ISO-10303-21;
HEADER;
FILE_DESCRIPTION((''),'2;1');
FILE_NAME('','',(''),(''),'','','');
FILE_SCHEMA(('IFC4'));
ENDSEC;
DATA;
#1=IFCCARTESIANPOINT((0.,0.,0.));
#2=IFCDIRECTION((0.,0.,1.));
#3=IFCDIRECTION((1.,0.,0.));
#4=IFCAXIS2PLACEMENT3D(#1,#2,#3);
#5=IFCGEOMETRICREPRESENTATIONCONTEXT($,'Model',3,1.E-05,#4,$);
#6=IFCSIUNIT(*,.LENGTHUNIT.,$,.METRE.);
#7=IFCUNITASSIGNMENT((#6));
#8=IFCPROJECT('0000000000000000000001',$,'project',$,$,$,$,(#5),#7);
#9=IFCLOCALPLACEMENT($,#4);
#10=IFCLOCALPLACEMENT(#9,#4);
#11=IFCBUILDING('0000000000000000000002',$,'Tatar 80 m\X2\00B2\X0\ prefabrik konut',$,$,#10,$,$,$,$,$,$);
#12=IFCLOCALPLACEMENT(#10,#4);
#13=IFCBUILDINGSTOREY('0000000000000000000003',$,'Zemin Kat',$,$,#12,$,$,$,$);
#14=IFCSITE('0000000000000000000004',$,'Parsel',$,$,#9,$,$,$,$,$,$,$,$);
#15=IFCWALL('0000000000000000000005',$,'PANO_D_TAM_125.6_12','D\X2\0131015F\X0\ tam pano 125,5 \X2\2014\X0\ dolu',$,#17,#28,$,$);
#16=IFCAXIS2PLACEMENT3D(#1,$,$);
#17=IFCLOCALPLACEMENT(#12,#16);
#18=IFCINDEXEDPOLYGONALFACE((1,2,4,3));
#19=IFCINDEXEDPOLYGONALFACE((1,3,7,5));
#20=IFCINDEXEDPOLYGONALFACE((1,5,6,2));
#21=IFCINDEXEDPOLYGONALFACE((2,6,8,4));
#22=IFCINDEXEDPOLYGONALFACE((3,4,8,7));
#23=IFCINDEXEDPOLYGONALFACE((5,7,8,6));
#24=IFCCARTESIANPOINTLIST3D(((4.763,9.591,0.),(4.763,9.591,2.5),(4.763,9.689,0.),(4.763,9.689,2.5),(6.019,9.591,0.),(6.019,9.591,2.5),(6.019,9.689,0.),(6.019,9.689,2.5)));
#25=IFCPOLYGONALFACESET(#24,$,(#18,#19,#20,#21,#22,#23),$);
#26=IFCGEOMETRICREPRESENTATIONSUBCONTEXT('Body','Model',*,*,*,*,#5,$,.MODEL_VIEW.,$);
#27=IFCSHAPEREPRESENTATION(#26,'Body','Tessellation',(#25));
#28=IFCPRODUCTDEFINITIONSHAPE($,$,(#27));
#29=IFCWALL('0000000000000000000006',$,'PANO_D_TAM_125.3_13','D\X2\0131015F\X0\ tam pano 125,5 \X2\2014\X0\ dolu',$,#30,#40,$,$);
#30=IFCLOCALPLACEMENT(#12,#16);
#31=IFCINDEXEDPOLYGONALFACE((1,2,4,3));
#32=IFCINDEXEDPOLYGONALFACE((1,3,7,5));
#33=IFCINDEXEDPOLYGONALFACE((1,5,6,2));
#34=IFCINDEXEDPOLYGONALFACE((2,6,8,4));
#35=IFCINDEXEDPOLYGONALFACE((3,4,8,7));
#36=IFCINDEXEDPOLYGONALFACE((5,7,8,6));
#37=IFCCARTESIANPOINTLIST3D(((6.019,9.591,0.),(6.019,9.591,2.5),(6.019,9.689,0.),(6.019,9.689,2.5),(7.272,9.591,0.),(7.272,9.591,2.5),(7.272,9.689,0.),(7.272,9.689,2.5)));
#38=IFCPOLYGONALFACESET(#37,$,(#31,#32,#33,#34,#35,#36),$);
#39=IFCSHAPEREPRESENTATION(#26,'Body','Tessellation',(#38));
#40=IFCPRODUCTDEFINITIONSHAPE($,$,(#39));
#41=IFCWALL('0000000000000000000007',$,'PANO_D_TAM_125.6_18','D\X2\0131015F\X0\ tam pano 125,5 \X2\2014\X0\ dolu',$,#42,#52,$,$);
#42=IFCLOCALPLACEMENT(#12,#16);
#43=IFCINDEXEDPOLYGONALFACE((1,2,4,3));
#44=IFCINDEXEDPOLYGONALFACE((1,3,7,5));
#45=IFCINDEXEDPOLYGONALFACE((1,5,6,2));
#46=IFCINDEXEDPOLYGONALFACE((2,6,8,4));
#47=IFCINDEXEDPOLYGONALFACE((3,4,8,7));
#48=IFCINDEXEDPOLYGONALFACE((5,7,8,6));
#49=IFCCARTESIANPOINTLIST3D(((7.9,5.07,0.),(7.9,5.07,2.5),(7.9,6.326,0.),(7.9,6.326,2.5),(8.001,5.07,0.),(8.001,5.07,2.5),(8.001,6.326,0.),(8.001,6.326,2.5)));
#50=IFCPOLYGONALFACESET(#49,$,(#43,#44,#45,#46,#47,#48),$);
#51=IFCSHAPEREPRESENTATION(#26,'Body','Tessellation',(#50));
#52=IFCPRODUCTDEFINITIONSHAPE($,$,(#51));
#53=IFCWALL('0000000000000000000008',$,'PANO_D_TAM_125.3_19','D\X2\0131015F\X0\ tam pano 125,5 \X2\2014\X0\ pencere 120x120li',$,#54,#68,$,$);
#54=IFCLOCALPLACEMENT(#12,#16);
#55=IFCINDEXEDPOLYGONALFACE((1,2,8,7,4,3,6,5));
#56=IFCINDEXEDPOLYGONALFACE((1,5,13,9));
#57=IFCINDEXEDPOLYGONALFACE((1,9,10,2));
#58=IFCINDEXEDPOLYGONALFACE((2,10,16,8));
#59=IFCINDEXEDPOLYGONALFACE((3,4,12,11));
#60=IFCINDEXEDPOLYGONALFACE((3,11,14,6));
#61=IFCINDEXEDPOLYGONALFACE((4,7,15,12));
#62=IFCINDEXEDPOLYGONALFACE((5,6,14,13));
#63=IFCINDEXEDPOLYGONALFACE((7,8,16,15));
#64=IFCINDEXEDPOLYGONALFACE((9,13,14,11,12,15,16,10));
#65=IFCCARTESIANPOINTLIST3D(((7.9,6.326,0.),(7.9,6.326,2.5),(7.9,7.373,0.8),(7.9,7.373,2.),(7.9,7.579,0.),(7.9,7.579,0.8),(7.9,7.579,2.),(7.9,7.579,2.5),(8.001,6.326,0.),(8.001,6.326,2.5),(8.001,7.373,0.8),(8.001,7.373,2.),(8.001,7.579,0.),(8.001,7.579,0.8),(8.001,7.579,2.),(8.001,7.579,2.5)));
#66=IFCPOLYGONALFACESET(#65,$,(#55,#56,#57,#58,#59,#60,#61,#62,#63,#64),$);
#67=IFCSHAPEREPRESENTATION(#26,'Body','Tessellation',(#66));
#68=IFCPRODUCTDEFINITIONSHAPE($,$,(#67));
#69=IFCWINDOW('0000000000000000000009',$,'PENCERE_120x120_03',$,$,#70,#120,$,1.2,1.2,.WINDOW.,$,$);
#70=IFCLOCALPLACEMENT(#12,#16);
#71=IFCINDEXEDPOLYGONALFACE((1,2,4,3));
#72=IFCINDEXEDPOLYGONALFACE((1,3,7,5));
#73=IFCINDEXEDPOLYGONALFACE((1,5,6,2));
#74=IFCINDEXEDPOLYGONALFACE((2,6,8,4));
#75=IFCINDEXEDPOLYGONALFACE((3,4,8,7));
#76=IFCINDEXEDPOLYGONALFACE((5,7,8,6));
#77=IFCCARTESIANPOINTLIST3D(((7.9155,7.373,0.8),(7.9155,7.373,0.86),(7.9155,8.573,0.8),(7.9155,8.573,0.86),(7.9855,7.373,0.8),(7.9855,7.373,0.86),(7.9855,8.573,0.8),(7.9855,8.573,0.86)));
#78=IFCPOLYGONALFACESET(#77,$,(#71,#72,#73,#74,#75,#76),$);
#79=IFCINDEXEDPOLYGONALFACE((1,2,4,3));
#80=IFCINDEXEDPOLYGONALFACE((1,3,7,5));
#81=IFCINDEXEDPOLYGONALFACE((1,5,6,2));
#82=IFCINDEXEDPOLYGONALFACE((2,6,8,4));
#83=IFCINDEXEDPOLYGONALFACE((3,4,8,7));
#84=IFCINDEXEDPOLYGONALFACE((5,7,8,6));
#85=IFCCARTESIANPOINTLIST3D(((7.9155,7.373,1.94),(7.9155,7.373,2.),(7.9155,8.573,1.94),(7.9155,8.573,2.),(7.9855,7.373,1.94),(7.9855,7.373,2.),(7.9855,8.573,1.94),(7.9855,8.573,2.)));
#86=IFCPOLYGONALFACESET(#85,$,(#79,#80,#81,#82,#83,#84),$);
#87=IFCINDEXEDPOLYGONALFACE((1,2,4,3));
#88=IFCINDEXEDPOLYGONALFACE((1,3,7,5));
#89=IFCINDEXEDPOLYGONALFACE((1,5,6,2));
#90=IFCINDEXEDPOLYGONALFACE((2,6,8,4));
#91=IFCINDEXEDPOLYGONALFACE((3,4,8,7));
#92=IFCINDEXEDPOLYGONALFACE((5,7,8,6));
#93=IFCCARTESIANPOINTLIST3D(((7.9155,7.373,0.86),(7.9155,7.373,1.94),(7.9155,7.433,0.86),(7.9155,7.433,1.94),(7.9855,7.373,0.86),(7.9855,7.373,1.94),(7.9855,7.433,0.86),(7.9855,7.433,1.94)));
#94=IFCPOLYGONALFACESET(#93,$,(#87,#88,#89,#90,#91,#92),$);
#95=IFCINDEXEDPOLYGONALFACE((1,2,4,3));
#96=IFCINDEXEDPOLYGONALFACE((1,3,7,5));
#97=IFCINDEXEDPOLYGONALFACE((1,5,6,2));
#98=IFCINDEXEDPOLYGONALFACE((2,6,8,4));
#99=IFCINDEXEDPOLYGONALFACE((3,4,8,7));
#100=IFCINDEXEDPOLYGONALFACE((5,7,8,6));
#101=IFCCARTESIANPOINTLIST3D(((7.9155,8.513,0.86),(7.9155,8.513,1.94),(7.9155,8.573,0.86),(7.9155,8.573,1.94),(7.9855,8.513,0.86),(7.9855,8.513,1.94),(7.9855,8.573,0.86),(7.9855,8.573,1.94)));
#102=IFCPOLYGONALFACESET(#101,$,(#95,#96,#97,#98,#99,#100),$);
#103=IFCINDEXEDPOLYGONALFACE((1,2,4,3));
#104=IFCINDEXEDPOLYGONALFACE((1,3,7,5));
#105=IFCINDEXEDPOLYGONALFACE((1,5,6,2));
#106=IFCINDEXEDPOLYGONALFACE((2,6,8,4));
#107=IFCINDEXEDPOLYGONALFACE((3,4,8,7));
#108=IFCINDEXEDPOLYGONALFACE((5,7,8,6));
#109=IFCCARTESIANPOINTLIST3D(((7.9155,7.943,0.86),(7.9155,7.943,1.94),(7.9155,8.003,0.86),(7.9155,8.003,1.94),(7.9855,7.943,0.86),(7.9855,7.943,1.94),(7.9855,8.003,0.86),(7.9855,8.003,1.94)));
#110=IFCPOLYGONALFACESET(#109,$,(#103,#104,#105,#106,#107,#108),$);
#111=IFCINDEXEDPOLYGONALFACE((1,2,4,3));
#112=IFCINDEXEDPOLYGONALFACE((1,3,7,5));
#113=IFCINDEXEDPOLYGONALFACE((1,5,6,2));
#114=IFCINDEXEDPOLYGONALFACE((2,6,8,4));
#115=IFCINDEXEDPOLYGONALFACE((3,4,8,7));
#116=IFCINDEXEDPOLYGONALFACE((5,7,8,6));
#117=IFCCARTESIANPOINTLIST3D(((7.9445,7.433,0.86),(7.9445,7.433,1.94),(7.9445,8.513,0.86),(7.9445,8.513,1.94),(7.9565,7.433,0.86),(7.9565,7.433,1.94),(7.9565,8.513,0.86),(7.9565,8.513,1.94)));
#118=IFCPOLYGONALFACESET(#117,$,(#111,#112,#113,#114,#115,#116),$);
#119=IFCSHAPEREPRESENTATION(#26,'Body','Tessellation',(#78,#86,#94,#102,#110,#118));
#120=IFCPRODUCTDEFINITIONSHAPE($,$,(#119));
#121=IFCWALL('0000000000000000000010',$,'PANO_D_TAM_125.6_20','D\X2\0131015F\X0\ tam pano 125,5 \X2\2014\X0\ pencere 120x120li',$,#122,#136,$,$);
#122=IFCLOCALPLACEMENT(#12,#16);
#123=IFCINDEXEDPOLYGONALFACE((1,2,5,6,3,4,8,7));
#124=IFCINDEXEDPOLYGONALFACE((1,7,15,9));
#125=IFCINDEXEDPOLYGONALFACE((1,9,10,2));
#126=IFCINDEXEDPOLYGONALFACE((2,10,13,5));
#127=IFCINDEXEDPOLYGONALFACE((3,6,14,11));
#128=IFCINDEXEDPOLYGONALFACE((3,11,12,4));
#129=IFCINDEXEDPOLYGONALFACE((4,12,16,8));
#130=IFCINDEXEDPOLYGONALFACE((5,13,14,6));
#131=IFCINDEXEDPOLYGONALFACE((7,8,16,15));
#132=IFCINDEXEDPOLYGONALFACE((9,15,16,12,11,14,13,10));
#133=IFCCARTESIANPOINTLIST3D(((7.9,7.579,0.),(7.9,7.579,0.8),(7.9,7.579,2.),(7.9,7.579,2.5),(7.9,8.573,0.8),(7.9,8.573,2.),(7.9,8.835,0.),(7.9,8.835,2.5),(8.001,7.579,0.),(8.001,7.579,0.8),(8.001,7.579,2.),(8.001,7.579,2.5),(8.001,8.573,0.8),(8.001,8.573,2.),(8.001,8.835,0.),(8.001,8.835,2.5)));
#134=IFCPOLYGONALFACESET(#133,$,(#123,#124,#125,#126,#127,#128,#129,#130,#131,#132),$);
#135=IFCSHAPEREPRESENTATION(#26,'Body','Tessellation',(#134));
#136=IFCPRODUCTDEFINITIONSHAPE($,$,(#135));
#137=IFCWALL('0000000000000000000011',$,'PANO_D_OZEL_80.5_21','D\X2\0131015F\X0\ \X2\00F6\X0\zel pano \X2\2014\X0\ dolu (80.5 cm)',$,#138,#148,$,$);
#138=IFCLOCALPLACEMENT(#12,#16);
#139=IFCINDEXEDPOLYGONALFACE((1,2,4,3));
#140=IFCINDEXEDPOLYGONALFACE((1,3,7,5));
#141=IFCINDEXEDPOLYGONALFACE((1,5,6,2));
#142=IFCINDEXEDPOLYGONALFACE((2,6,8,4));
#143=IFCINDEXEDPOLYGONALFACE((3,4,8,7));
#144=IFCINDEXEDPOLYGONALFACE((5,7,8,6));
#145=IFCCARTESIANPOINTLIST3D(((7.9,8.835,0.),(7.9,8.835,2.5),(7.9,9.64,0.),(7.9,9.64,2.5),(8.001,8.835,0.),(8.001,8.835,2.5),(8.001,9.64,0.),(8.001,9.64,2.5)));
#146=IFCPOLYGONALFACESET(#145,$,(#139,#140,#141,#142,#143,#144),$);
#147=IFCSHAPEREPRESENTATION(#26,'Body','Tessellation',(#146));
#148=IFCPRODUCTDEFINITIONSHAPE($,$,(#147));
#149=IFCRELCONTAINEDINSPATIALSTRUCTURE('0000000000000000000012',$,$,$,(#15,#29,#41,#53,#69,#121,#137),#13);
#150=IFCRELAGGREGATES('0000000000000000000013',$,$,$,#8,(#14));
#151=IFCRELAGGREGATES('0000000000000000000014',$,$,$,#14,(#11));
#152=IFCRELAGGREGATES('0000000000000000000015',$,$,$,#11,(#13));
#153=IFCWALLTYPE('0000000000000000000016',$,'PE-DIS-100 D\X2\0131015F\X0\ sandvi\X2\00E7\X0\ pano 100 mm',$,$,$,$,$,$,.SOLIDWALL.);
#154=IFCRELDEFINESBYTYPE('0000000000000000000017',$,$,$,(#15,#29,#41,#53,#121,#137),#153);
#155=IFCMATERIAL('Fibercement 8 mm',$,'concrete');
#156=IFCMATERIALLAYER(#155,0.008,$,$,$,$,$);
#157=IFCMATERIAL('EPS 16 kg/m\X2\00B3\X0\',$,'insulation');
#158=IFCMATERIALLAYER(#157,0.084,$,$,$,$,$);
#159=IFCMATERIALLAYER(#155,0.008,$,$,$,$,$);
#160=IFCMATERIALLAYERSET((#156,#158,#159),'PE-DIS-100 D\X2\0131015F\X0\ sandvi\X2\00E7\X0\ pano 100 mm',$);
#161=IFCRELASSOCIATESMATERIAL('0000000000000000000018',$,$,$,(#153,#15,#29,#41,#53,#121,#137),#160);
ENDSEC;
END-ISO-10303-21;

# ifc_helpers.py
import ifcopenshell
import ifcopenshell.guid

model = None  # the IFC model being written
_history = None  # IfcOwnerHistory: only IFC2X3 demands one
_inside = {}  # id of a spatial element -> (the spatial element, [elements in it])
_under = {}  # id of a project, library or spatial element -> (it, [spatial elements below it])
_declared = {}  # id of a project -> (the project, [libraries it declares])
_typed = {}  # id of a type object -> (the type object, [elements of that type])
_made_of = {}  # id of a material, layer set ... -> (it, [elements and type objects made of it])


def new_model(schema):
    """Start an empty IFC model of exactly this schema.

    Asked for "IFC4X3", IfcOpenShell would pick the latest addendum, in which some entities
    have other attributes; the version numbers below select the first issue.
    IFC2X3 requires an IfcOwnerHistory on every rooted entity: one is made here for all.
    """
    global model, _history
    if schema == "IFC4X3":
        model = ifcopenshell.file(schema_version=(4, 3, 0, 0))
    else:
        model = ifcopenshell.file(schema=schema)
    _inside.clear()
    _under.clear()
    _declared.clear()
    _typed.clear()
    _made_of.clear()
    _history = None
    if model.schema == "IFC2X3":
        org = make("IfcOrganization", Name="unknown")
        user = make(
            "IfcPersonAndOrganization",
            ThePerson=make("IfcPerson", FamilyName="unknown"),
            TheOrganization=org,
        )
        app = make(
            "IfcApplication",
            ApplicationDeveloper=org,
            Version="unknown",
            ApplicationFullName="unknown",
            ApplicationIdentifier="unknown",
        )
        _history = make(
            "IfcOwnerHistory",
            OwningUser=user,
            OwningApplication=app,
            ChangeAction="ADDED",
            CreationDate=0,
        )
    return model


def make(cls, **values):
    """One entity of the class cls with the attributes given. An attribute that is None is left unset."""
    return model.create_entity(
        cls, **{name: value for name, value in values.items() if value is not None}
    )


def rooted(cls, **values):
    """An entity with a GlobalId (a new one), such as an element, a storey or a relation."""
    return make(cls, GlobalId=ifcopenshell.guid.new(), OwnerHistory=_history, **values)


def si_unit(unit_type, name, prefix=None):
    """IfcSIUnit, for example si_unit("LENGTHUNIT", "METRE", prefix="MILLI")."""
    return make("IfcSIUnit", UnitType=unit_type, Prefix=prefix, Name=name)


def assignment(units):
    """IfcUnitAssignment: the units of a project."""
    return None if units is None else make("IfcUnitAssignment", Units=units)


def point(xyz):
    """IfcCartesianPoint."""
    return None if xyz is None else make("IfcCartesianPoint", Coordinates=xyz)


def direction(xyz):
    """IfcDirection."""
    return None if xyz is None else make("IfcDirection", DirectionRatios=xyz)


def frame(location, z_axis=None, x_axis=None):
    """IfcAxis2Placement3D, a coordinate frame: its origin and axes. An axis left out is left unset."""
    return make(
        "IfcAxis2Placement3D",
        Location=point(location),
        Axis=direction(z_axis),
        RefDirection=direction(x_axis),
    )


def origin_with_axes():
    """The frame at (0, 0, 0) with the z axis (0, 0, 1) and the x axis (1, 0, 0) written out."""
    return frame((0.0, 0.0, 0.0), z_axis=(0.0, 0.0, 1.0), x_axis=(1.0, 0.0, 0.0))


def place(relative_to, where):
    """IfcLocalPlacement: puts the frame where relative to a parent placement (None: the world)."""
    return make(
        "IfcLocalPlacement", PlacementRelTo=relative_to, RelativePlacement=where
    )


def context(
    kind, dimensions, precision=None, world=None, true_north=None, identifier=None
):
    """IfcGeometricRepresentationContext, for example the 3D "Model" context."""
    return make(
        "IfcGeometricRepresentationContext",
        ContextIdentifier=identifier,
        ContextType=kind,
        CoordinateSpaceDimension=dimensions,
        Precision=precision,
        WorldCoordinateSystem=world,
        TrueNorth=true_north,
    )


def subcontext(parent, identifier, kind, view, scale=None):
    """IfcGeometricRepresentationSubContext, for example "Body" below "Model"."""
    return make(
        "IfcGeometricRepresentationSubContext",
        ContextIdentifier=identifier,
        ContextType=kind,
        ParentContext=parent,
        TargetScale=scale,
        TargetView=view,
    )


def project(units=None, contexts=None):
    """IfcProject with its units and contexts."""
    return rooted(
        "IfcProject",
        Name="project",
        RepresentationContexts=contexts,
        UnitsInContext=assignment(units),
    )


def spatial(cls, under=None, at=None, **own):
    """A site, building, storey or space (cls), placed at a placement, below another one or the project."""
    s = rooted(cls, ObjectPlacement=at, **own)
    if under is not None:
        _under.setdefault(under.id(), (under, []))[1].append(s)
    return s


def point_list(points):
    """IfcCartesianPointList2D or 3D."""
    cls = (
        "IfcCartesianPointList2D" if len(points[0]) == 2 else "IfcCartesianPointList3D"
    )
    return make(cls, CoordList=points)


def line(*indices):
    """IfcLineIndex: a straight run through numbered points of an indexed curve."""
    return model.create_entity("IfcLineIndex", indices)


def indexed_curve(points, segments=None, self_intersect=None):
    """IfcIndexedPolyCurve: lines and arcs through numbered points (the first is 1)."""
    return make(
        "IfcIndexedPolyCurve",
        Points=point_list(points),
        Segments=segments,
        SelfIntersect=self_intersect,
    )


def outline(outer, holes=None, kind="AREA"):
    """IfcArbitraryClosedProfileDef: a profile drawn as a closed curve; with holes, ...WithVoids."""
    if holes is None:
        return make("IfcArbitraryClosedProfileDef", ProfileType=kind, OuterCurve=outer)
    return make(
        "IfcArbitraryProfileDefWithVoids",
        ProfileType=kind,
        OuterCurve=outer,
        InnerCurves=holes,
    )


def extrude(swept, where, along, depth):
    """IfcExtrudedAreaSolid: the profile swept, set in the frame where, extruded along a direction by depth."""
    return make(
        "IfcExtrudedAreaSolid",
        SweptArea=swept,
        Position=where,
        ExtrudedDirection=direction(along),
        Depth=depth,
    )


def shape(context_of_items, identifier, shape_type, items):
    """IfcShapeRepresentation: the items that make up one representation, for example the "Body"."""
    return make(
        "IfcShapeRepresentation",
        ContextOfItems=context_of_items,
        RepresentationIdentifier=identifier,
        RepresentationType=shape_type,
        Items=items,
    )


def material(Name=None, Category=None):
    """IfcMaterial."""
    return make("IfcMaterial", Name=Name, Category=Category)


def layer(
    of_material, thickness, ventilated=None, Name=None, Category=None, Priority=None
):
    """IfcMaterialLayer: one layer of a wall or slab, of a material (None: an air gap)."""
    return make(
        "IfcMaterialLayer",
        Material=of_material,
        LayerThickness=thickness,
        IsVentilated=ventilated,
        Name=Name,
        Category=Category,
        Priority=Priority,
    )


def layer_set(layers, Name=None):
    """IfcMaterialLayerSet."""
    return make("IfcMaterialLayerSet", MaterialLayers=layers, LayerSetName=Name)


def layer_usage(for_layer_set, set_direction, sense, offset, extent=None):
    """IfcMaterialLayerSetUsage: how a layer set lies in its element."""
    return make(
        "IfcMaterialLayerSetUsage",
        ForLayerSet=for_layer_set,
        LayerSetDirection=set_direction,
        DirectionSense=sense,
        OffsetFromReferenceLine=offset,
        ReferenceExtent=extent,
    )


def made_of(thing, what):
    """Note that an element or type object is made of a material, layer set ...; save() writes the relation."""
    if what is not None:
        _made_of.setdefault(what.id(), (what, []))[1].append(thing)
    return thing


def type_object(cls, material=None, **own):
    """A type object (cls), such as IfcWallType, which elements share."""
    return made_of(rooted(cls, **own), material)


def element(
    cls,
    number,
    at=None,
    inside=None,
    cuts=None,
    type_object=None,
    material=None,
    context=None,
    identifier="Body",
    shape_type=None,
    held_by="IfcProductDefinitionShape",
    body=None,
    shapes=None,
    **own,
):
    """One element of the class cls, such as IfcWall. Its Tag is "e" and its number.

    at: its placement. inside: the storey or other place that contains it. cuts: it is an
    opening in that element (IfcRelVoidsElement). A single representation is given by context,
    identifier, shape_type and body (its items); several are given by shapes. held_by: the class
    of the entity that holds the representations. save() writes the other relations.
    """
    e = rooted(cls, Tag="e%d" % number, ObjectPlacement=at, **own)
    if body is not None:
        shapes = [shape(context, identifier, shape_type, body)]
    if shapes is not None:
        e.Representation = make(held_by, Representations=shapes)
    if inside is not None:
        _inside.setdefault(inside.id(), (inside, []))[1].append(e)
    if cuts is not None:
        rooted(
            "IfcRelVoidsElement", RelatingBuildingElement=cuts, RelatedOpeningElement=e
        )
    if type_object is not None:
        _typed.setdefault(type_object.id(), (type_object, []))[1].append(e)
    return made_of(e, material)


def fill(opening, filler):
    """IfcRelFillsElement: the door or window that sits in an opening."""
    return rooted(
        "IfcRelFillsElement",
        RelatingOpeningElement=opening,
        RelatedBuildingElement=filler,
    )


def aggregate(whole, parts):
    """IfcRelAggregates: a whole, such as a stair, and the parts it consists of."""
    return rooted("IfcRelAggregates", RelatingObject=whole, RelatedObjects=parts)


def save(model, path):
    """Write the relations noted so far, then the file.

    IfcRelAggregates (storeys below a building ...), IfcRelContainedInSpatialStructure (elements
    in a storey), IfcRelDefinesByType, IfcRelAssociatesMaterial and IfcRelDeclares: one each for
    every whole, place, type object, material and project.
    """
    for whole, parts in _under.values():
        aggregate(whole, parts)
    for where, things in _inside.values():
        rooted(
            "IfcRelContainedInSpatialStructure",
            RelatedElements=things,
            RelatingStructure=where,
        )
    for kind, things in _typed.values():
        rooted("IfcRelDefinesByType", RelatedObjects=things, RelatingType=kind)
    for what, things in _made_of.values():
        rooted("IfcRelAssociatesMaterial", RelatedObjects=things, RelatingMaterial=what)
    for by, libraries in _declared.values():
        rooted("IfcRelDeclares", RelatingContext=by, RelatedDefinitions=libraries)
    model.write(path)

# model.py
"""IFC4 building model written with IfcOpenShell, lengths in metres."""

from ifc_helpers import new_model, si_unit, frame, origin_with_axes, place, context, subcontext, project, spatial, line, indexed_curve, outline, extrude, material, layer, layer_set, layer_usage, type_object, element, fill, save


model = new_model("IFC4")

# Units and contexts
model_context = context("Model", 3, precision=1e-05, world=origin_with_axes())
body_context = subcontext(model_context, "Body", "Model", "MODEL_VIEW")
ifc_project = project(units=[si_unit("LENGTHUNIT", "METRE")], contexts=[model_context])

# Site, building, storey
site_placement = place(None, origin_with_axes())
site = spatial("IfcSite", under=ifc_project, at=site_placement, Name="Parsel")
building_placement = place(site_placement, origin_with_axes())
building = spatial("IfcBuilding", under=site, at=building_placement, Name="Tatar 80 m² prefabrik konut")
storey_placement = place(building_placement, origin_with_axes())
storey = spatial("IfcBuildingStorey", under=building, at=storey_placement, Name="Zemin Kat")

# Walls
ifc_material_1 = material(Name="Fibercement 8 mm", Category="concrete")
ifc_layer_1 = layer(ifc_material_1, 0.008)
ifc_material_2 = material(Name="EPS 16 kg/m³", Category="insulation")
ifc_layer_2 = layer(ifc_material_2, 0.084)
ifc_layer_3 = layer(ifc_material_1, 0.008)
ifc_layer_set_1 = layer_set([ifc_layer_1, ifc_layer_2, ifc_layer_3], Name="PE-DIS-100 Dış sandviç pano 100 mm")
ifc_layer_usage_1 = layer_usage(ifc_layer_set_1, "AXIS2", "POSITIVE", 0.0)
wall_type_1 = type_object("IfcWallType", Name="PE-DIS-100 Dış sandviç pano 100 mm", PredefinedType="SOLIDWALL", material=ifc_layer_set_1)
wall_1_placement = place(storey_placement, frame((4.763, 9.591, 0.0), z_axis=(0.0, 0.0, 1.0), x_axis=(1.0, 0.0, 0.0)))
element("IfcWall", 1, at=wall_1_placement, inside=storey, type_object=wall_type_1, material=ifc_layer_usage_1, Name="PANO_D_TAM_125.6_12", Description="Dış tam pano 125,5 — dolu", context=body_context, shape_type="SweptSolid", body=[
    extrude(outline(indexed_curve([(0.0, 0.0), (1.256, 0.0), (1.256, 0.098), (0.0, 0.098)], segments=[line(1, 2, 3, 4, 1)])), origin_with_axes(), (0.0, 0.0, 1.0), 2.5),
])
ifc_layer_usage_2 = layer_usage(ifc_layer_set_1, "AXIS2", "POSITIVE", 0.0)
wall_2_placement = place(storey_placement, frame((6.019, 9.591, 0.0), z_axis=(0.0, 0.0, 1.0), x_axis=(1.0, 0.0, 0.0)))
element("IfcWall", 2, at=wall_2_placement, inside=storey, type_object=wall_type_1, material=ifc_layer_usage_2, Name="PANO_D_TAM_125.3_13", Description="Dış tam pano 125,5 — dolu", context=body_context, shape_type="SweptSolid", body=[
    extrude(outline(indexed_curve([(0.0, 0.0), (1.253, 0.0), (1.253, 0.098), (0.0, 0.098)], segments=[line(1, 2, 3, 4, 1)])), origin_with_axes(), (0.0, 0.0, 1.0), 2.5),
])
ifc_layer_usage_3 = layer_usage(ifc_layer_set_1, "AXIS2", "POSITIVE", 0.0)
wall_3_placement = place(storey_placement, frame((8.001, 5.07, 0.0), z_axis=(0.0, 0.0, 1.0), x_axis=(0.0, 1.0, 0.0)))
element("IfcWall", 3, at=wall_3_placement, inside=storey, type_object=wall_type_1, material=ifc_layer_usage_3, Name="PANO_D_TAM_125.6_18", Description="Dış tam pano 125,5 — dolu", context=body_context, shape_type="SweptSolid", body=[
    extrude(outline(indexed_curve([(0.0, 0.0), (1.256, 0.0), (1.256, 0.101), (0.0, 0.101)], segments=[line(1, 2, 3, 4, 1)])), origin_with_axes(), (0.0, 0.0, 1.0), 2.5),
])

# Wall, opening, window
ifc_layer_usage_4 = layer_usage(ifc_layer_set_1, "AXIS2", "POSITIVE", 0.0)
wall_4_placement = place(storey_placement, frame((8.001, 6.326, 0.0), z_axis=(0.0, 0.0, 1.0), x_axis=(0.0, 1.0, 0.0)))
wall_4 = element("IfcWall", 4, at=wall_4_placement, inside=storey, type_object=wall_type_1, material=ifc_layer_usage_4, Name="PANO_D_TAM_125.3_19", Description="Dış tam pano 125,5 — pencere 120x120li", context=body_context, shape_type="SweptSolid", body=[
    extrude(outline(indexed_curve([(0.0, 0.0), (1.253, 0.0), (1.253, 0.101), (0.0, 0.101)], segments=[line(1, 2, 3, 4, 1)])), origin_with_axes(), (0.0, 0.0, 1.0), 2.5),
])
opening_1_placement = place(wall_4_placement, origin_with_axes())
opening_1 = element("IfcOpeningElement", 5, at=opening_1_placement, cuts=wall_4, PredefinedType="OPENING", context=body_context, shape_type="SweptSolid", body=[
    extrude(outline(indexed_curve([(0.0, 0.0), (0.206, 0.0), (0.206, 0.141), (0.0, 0.141)], segments=[line(1, 2, 3, 4, 1)])), frame((1.047, -0.02, 0.8), z_axis=(0.0, 0.0, 1.0), x_axis=(1.0, 0.0, 0.0)), (0.0, 0.0, 1.0), 1.2),
])
window_1_placement = place(storey_placement, frame((8.001, 6.326, 0.0), z_axis=(0.0, 0.0, 1.0), x_axis=(0.0, 1.0, 0.0)))
window_1 = element("IfcWindow", 6, at=window_1_placement, inside=storey, Name="PENCERE_120x120_03", OverallHeight=1.2, OverallWidth=1.2, PredefinedType="WINDOW", context=body_context, shape_type="SweptSolid", body=[
    extrude(outline(indexed_curve([(0.0, 0.0), (1.2, 0.0), (1.2, 0.07), (0.0, 0.07)], segments=[line(1, 2, 3, 4, 1)])), frame((1.047, 0.0155, 0.8), z_axis=(0.0, 0.0, 1.0), x_axis=(1.0, 0.0, 0.0)), (0.0, 0.0, 1.0), 0.06),
    extrude(outline(indexed_curve([(0.0, 0.0), (1.2, 0.0), (1.2, 0.07), (0.0, 0.07)], segments=[line(1, 2, 3, 4, 1)])), frame((1.047, 0.0155, 1.94), z_axis=(0.0, 0.0, 1.0), x_axis=(1.0, 0.0, 0.0)), (0.0, 0.0, 1.0), 0.06),
    extrude(outline(indexed_curve([(0.0, 0.0), (0.06, 0.0), (0.06, 0.07), (0.0, 0.07)], segments=[line(1, 2, 3, 4, 1)])), frame((1.047, 0.0155, 0.86), z_axis=(0.0, 0.0, 1.0), x_axis=(1.0, 0.0, 0.0)), (0.0, 0.0, 1.0), 1.08),
    extrude(outline(indexed_curve([(0.0, 0.0), (0.06, 0.0), (0.06, 0.07), (0.0, 0.07)], segments=[line(1, 2, 3, 4, 1)])), frame((2.187, 0.0155, 0.86), z_axis=(0.0, 0.0, 1.0), x_axis=(1.0, 0.0, 0.0)), (0.0, 0.0, 1.0), 1.08),
    extrude(outline(indexed_curve([(0.0, 0.0), (0.06, 0.0), (0.06, 0.07), (0.0, 0.07)], segments=[line(1, 2, 3, 4, 1)])), frame((1.617, 0.0155, 0.86), z_axis=(0.0, 0.0, 1.0), x_axis=(1.0, 0.0, 0.0)), (0.0, 0.0, 1.0), 1.08),
    extrude(outline(indexed_curve([(0.0, 0.0), (1.08, 0.0), (1.08, 0.012), (0.0, 0.012)], segments=[line(1, 2, 3, 4, 1)])), frame((1.107, 0.0445, 0.86), z_axis=(0.0, 0.0, 1.0), x_axis=(1.0, 0.0, 0.0)), (0.0, 0.0, 1.0), 1.08),
])
fill(opening_1, window_1)

# Wall, opening
ifc_layer_usage_5 = layer_usage(ifc_layer_set_1, "AXIS2", "POSITIVE", 0.0)
wall_5_placement = place(storey_placement, frame((8.001, 7.579, 0.0), z_axis=(0.0, 0.0, 1.0), x_axis=(0.0, 1.0, 0.0)))
wall_5 = element("IfcWall", 7, at=wall_5_placement, inside=storey, type_object=wall_type_1, material=ifc_layer_usage_5, Name="PANO_D_TAM_125.6_20", Description="Dış tam pano 125,5 — pencere 120x120li", context=body_context, shape_type="SweptSolid", body=[
    extrude(outline(indexed_curve([(0.0, 0.0), (1.256, 0.0), (1.256, 0.101), (0.0, 0.101)], segments=[line(1, 2, 3, 4, 1)])), origin_with_axes(), (0.0, 0.0, 1.0), 2.5),
])
opening_2_placement = place(wall_5_placement, origin_with_axes())
element("IfcOpeningElement", 8, at=opening_2_placement, cuts=wall_5, PredefinedType="OPENING", context=body_context, shape_type="SweptSolid", body=[
    extrude(outline(indexed_curve([(0.0, 0.0), (0.994, 0.0), (0.994, 0.141), (0.0, 0.141)], segments=[line(1, 2, 3, 4, 1)])), frame((0.0, -0.02, 0.8), z_axis=(0.0, 0.0, 1.0), x_axis=(1.0, 0.0, 0.0)), (0.0, 0.0, 1.0), 1.2),
])

# Wall
ifc_layer_usage_6 = layer_usage(ifc_layer_set_1, "AXIS2", "POSITIVE", 0.0)
wall_6_placement = place(storey_placement, frame((8.001, 8.835, 0.0), z_axis=(0.0, 0.0, 1.0), x_axis=(0.0, 1.0, 0.0)))
element("IfcWall", 9, at=wall_6_placement, inside=storey, type_object=wall_type_1, material=ifc_layer_usage_6, Name="PANO_D_OZEL_80.5_21", Description="Dış özel pano — dolu (80.5 cm)", context=body_context, shape_type="SweptSolid", body=[
    extrude(outline(indexed_curve([(0.0, 0.0), (0.805, 0.0), (0.805, 0.101), (0.0, 0.101)], segments=[line(1, 2, 3, 4, 1)])), origin_with_axes(), (0.0, 0.0, 1.0), 2.5),
])

save(model, "model.ifc")
